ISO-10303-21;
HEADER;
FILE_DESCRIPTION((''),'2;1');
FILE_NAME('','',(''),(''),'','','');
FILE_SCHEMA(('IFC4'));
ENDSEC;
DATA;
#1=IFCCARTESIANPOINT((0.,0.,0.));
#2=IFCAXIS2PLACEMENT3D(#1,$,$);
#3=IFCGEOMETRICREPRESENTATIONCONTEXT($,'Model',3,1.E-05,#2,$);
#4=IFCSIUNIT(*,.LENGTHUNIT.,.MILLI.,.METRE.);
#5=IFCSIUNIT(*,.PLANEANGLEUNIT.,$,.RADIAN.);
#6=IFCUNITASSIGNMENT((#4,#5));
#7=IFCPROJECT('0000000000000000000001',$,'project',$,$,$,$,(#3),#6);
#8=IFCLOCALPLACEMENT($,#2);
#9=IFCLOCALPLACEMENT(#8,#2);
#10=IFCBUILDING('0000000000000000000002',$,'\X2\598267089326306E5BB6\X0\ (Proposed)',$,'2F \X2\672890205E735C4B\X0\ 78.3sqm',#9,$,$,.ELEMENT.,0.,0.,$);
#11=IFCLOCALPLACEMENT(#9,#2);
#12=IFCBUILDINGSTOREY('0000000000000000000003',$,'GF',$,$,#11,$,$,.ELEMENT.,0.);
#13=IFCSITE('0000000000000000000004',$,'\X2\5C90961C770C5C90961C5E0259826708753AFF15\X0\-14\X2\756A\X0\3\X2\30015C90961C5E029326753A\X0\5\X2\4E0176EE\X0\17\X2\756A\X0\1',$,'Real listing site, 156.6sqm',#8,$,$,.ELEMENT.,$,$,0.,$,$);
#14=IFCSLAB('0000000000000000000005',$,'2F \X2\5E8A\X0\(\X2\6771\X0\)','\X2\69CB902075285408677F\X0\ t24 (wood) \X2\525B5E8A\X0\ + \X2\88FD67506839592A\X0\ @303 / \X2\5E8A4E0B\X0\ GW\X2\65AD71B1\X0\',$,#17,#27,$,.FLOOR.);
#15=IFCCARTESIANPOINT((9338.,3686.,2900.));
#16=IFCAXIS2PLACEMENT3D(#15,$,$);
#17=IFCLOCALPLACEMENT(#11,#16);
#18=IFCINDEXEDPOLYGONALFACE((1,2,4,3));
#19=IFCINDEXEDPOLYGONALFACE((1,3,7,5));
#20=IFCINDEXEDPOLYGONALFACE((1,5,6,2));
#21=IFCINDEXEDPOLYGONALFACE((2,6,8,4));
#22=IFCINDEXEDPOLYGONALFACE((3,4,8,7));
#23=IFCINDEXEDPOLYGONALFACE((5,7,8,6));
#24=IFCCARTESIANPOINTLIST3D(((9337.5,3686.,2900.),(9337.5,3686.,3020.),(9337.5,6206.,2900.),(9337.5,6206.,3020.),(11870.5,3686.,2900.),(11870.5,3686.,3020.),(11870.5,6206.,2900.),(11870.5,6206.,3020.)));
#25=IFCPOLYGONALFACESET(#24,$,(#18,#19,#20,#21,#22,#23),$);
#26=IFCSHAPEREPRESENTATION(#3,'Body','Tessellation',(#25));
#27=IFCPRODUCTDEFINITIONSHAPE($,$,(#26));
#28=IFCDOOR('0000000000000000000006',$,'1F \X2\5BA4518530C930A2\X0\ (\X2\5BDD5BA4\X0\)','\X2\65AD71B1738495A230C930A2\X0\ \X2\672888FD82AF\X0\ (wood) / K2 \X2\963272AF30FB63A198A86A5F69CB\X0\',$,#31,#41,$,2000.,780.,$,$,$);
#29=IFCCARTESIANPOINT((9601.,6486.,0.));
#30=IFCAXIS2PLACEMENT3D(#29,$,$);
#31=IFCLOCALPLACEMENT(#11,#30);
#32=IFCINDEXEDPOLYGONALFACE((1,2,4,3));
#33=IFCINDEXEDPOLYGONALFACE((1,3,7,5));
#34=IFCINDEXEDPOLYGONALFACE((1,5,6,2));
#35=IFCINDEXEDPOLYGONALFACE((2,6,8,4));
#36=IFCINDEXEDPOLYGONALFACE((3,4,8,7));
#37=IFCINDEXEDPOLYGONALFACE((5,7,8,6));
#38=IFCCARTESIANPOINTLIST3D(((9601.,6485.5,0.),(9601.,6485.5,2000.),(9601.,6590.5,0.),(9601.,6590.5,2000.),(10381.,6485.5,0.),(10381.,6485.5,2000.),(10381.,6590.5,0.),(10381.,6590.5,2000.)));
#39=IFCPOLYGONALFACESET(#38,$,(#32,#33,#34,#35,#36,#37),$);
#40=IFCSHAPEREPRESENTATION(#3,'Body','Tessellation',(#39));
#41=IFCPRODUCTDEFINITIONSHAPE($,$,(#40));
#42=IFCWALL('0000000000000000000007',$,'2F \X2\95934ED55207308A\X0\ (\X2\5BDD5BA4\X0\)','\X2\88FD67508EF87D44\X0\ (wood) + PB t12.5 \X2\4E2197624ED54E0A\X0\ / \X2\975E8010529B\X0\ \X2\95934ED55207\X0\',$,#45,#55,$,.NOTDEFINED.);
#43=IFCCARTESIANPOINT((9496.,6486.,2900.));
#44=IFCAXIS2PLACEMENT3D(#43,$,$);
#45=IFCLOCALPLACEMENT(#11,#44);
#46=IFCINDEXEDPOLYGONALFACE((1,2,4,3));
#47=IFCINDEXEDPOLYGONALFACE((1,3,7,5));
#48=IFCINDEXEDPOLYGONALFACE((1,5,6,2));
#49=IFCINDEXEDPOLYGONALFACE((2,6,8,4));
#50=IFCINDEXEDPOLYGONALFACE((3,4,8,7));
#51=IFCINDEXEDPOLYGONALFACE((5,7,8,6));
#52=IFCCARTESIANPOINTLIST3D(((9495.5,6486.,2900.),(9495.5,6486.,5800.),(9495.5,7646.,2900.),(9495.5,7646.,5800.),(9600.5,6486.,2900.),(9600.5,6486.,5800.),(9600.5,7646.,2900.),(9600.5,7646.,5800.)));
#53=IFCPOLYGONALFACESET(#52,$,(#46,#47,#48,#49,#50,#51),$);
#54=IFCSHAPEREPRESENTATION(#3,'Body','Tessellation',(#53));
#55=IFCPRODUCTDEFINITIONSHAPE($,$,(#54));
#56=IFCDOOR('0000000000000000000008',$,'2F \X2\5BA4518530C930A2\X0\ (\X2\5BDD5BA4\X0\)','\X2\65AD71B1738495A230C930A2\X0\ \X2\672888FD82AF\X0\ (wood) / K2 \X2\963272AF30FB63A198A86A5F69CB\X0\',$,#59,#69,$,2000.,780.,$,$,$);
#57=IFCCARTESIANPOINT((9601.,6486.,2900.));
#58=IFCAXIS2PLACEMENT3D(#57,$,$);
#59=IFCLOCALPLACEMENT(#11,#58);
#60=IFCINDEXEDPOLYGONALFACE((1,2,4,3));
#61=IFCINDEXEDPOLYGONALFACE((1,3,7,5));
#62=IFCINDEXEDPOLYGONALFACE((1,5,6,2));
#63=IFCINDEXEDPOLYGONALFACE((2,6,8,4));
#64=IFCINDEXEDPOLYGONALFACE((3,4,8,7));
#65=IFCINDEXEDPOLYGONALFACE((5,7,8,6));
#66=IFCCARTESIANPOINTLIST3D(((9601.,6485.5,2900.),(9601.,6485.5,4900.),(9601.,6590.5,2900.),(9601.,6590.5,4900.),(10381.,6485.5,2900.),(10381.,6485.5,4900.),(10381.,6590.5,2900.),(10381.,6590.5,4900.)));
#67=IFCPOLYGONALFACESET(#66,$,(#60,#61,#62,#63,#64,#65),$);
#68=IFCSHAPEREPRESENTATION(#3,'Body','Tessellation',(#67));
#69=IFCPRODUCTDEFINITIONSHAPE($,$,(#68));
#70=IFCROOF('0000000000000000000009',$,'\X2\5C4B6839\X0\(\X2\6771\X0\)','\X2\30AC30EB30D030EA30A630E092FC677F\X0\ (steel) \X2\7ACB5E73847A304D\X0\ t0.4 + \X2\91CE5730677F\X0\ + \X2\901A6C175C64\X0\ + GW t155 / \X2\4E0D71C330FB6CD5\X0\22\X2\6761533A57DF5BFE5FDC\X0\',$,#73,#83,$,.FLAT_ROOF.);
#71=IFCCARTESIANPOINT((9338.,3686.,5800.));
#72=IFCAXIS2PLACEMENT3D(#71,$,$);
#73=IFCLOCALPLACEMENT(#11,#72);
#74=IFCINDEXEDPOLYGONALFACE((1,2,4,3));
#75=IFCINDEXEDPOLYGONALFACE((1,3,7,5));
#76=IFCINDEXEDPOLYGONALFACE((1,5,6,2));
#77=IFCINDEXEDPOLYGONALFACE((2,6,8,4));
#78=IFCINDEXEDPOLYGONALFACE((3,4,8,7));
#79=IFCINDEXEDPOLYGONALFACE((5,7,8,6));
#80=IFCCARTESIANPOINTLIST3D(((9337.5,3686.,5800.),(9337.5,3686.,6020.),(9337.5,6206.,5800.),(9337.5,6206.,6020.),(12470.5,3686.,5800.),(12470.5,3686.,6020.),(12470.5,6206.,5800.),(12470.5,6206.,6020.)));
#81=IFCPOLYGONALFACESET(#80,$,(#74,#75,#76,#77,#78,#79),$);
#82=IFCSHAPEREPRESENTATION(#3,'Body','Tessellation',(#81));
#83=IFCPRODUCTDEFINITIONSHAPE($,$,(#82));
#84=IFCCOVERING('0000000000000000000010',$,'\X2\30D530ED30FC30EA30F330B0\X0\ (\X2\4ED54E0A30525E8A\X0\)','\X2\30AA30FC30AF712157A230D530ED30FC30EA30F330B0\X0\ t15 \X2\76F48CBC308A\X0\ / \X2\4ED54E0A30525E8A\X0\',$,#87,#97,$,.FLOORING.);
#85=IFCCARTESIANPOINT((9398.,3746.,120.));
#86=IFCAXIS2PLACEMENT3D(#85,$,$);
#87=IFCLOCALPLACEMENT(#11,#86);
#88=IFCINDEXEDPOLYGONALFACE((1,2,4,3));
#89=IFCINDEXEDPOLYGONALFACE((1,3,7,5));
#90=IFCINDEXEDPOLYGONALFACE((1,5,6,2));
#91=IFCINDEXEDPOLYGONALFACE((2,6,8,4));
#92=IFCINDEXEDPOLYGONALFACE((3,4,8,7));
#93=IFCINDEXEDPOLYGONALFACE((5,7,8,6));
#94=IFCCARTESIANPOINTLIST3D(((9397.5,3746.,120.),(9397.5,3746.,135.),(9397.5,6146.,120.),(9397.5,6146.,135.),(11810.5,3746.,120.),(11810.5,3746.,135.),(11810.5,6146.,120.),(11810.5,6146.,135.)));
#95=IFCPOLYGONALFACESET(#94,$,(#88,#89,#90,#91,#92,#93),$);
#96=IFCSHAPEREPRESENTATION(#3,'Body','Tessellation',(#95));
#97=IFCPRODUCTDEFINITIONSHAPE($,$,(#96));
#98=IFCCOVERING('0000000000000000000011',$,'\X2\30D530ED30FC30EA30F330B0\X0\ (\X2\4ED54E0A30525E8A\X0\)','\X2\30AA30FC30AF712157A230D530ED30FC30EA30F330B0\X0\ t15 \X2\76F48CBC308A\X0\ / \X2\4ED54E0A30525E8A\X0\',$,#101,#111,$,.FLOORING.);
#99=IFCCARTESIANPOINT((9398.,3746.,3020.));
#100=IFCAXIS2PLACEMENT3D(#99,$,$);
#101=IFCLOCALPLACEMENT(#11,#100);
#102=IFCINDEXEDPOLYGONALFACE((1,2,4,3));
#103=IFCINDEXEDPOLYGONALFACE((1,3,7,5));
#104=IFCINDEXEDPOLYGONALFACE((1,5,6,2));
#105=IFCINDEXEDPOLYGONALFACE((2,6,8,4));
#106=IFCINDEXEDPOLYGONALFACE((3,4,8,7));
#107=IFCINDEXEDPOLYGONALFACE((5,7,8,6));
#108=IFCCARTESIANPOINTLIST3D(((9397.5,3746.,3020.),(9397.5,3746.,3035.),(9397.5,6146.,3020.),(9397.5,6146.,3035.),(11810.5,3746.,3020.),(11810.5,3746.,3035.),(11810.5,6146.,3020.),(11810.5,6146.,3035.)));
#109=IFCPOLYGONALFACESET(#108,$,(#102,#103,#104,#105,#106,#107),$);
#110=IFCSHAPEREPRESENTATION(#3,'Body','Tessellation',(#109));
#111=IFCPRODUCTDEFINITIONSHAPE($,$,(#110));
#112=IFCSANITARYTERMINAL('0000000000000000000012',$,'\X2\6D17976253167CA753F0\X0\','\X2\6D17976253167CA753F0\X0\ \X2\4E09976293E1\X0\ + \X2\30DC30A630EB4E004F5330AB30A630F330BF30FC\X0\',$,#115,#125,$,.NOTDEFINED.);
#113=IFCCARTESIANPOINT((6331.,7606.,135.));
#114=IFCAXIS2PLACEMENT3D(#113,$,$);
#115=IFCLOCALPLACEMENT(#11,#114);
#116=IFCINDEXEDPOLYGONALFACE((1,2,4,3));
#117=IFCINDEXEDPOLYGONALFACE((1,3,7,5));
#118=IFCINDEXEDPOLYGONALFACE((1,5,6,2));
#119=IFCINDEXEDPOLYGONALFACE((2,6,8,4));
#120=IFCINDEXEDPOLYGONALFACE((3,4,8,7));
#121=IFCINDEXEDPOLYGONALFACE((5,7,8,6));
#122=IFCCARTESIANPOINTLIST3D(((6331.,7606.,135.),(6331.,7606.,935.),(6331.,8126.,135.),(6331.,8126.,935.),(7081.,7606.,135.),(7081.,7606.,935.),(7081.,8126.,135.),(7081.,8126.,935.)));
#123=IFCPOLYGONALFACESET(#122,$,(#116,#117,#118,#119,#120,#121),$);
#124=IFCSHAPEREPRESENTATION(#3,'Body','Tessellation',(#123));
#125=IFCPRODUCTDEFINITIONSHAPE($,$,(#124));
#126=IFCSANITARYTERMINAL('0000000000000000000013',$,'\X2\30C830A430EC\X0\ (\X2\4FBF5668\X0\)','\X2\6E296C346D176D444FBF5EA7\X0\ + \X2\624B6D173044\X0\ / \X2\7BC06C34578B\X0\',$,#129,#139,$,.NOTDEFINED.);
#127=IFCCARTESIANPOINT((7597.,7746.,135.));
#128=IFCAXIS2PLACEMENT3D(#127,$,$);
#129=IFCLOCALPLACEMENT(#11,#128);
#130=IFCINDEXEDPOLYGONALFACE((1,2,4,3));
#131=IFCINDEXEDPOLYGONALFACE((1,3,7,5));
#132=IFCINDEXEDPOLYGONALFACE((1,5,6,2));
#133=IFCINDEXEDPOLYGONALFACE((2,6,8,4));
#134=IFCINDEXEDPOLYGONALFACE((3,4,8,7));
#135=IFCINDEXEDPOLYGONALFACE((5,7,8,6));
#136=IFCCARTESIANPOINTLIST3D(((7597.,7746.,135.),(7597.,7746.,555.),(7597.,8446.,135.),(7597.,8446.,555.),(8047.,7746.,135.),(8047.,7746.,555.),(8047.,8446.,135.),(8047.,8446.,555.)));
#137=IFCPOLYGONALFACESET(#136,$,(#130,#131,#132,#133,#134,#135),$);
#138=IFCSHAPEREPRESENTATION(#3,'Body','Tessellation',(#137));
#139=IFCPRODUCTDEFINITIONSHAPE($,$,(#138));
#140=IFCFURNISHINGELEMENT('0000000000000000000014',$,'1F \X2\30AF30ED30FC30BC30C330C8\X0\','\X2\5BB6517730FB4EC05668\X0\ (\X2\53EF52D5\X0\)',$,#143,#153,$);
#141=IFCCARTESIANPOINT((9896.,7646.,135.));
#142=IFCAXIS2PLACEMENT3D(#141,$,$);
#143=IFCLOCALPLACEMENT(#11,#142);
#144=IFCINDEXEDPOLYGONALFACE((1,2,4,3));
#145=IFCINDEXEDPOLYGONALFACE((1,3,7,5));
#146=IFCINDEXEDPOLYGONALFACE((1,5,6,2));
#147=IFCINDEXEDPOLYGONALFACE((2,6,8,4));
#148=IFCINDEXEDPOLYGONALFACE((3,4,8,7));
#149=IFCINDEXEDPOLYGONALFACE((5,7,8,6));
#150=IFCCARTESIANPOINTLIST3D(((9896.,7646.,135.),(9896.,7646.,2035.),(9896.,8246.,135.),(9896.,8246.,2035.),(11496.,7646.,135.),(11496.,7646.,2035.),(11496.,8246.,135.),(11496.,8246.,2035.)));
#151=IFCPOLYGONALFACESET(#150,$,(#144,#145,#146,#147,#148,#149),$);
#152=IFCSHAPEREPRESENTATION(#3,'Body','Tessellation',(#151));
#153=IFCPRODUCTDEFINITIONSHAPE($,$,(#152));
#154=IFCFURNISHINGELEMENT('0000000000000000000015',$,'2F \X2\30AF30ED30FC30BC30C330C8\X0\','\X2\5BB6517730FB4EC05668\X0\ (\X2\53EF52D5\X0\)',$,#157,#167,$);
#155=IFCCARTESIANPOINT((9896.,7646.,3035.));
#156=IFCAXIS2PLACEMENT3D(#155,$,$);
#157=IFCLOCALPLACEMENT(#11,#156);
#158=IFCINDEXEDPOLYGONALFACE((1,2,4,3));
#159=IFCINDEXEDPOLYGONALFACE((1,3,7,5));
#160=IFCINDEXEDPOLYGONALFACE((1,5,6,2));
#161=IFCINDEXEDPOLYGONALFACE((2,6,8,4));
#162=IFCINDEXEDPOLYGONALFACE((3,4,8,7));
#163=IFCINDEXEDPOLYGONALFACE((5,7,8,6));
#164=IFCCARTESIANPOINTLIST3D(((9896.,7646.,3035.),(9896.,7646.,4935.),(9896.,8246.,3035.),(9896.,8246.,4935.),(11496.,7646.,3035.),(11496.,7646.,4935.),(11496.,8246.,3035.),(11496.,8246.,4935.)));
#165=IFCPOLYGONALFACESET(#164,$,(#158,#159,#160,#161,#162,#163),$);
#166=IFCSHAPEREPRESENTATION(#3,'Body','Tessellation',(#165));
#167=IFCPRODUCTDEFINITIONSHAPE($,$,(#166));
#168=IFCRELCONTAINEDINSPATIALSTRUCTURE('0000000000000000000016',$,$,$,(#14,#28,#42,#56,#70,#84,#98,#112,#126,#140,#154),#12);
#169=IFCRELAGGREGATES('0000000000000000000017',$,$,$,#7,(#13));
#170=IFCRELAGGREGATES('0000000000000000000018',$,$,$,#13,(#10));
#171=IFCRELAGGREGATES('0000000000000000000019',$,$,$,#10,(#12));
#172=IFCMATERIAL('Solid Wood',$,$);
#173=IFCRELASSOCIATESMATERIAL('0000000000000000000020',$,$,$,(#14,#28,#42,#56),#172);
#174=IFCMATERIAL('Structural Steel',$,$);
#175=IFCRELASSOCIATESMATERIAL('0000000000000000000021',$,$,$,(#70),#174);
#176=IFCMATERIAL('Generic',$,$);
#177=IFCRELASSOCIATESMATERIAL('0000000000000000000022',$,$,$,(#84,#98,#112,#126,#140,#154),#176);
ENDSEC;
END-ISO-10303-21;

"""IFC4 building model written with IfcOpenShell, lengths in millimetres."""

from ifc_helpers import new_model, si_unit, frame, frame_2d, origin, place, context, project, spatial, rectangle, extrude, material, element, save


model = new_model("IFC4")

# Units and contexts
model_context = context("Model", 3, precision=1e-05, world=origin())
ifc_project = project(units=[si_unit("LENGTHUNIT", "METRE", prefix="MILLI"), si_unit("PLANEANGLEUNIT", "RADIAN")], contexts=[model_context])

# Site, building, storey
site_placement = place(None, origin())
site = spatial("IfcSite", under=ifc_project, at=site_placement, Name="岐阜県岐阜市如月町５-14番3、岐阜市錦町5丁目17番1", ObjectType="Real listing site, 156.6sqm", CompositionType="ELEMENT", RefElevation=0.0)
building_placement = place(site_placement, origin())
building = spatial("IfcBuilding", under=site, at=building_placement, Name="如月錦の家 (Proposed)", ObjectType="2F 木造平屋 78.3sqm", CompositionType="ELEMENT", ElevationOfRefHeight=0.0, ElevationOfTerrain=0.0)
storey_placement = place(building_placement, origin())
storey = spatial("IfcBuildingStorey", under=building, at=storey_placement, Name="GF", CompositionType="ELEMENT", Elevation=0.0)

# Slab
ifc_material_1 = material(Name="Solid Wood")
slab_1_placement = place(storey_placement, frame((9338.0, 3686.0, 2900.0)))
element("IfcSlab", 1, at=slab_1_placement, inside=storey, material=ifc_material_1, Name="2F 床(東)", Description="構造用合板 t24 (wood) 剛床 + 製材根太 @303 / 床下 GW断熱", PredefinedType="FLOOR", context=model_context, shape_type="SweptSolid", body=[
    extrude(rectangle(XDim=2533.0, YDim=2520.0, at=frame_2d((1266.0, 1260.0))), frame((9338.0, 3686.0, 2900.0)), (0.0, 0.0, 1.0), 120.0),
])

# Door
door_1_placement = place(storey_placement, frame((9601.0, 6486.0, 0.0)))
element("IfcDoor", 2, at=door_1_placement, inside=storey, material=ifc_material_1, Name="1F 室内ドア (寝室)", Description="断熱玄関ドア 木製芯 (wood) / K2 防犯・採風機構", OverallHeight=2000.0, OverallWidth=780.0, context=model_context, shape_type="SweptSolid", body=[
    extrude(rectangle(XDim=780.0, YDim=105.0, at=frame_2d((390.0, 52.0))), frame((9601.0, 6486.0, 0.0)), (0.0, 0.0, 1.0), 2000.0),
])

# Wall
wall_1_placement = place(storey_placement, frame((9496.0, 6486.0, 2900.0)))
element("IfcWall", 3, at=wall_1_placement, inside=storey, material=ifc_material_1, Name="2F 間仕切り (寝室)", Description="製材軸組 (wood) + PB t12.5 両面仕上 / 非耐力 間仕切", PredefinedType="NOTDEFINED", context=model_context, shape_type="SweptSolid", body=[
    extrude(rectangle(XDim=105.0, YDim=1160.0, at=frame_2d((52.0, 580.0))), frame((9496.0, 6486.0, 2900.0)), (0.0, 0.0, 1.0), 2900.0),
])

# Door
door_2_placement = place(storey_placement, frame((9601.0, 6486.0, 2900.0)))
element("IfcDoor", 4, at=door_2_placement, inside=storey, material=ifc_material_1, Name="2F 室内ドア (寝室)", Description="断熱玄関ドア 木製芯 (wood) / K2 防犯・採風機構", OverallHeight=2000.0, OverallWidth=780.0, context=model_context, shape_type="SweptSolid", body=[
    extrude(rectangle(XDim=780.0, YDim=105.0, at=frame_2d((390.0, 52.0))), frame((9601.0, 6486.0, 2900.0)), (0.0, 0.0, 1.0), 2000.0),
])

# Roof
ifc_material_2 = material(Name="Structural Steel")
for number, where, name in (
    (5, (9338.0, 3686.0, 5800.0), "屋根(東)"),
):
    element("IfcRoof", number, at=place(storey_placement, frame(where)), inside=storey, material=ifc_material_2, Name=name, Description="ガルバリウム鋼板 (steel) 立平葺き t0.4 + 野地板 + 通気層 + GW t155 / 不燃・法22条区域対応", PredefinedType="FLAT_ROOF", context=model_context, shape_type="SweptSolid", body=[
        extrude(rectangle(XDim=3133.0, YDim=2520.0, at=frame_2d((1566.0, 1260.0))), frame((9338.0, 3686.0, 5800.0)), (0.0, 0.0, 1.0), 220.0),
    ])

# Coverings
ifc_material_3 = material(Name="Generic")
covering_1_placement = place(storey_placement, frame((9398.0, 3746.0, 120.0)))
element("IfcCovering", 6, at=covering_1_placement, inside=storey, material=ifc_material_3, Name="フローリング (仕上げ床)", Description="オーク無垢フローリング t15 直貼り / 仕上げ床", PredefinedType="FLOORING", context=model_context, shape_type="SweptSolid", body=[
    extrude(rectangle(XDim=2413.0, YDim=2400.0, at=frame_2d((1206.0, 1200.0))), frame((9398.0, 3746.0, 120.0)), (0.0, 0.0, 1.0), 15.0),
])
covering_2_placement = place(storey_placement, frame((9398.0, 3746.0, 3020.0)))
element("IfcCovering", 7, at=covering_2_placement, inside=storey, material=ifc_material_3, Name="フローリング (仕上げ床)", Description="オーク無垢フローリング t15 直貼り / 仕上げ床", PredefinedType="FLOORING", context=model_context, shape_type="SweptSolid", body=[
    extrude(rectangle(XDim=2413.0, YDim=2400.0, at=frame_2d((1206.0, 1200.0))), frame((9398.0, 3746.0, 3020.0)), (0.0, 0.0, 1.0), 15.0),
])

# Sanitary terminals
sanitary_terminal_1_placement = place(storey_placement, frame((6331.0, 7606.0, 135.0)))
element("IfcSanitaryTerminal", 8, at=sanitary_terminal_1_placement, inside=storey, material=ifc_material_3, Name="洗面化粧台", Description="洗面化粧台 三面鏡 + ボウル一体カウンター", PredefinedType="NOTDEFINED", context=model_context, shape_type="SweptSolid", body=[
    extrude(rectangle(XDim=750.0, YDim=520.0, at=frame_2d((375.0, 260.0))), frame((6331.0, 7606.0, 135.0)), (0.0, 0.0, 1.0), 800.0),
])
sanitary_terminal_2_placement = place(storey_placement, frame((7597.0, 7746.0, 135.0)))
element("IfcSanitaryTerminal", 9, at=sanitary_terminal_2_placement, inside=storey, material=ifc_material_3, Name="トイレ (便器)", Description="温水洗浄便座 + 手洗い / 節水型", PredefinedType="NOTDEFINED", context=model_context, shape_type="SweptSolid", body=[
    extrude(rectangle(XDim=450.0, YDim=700.0, at=frame_2d((225.0, 350.0))), frame((7597.0, 7746.0, 135.0)), (0.0, 0.0, 1.0), 420.0),
])

# Furnishing elements
furnishing_1_placement = place(storey_placement, frame((9896.0, 7646.0, 135.0)))
element("IfcFurnishingElement", 10, at=furnishing_1_placement, inside=storey, material=ifc_material_3, Name="1F クローゼット", Description="家具・什器 (可動)", context=model_context, shape_type="SweptSolid", body=[
    extrude(rectangle(XDim=1600.0, YDim=600.0, at=frame_2d((800.0, 300.0))), frame((9896.0, 7646.0, 135.0)), (0.0, 0.0, 1.0), 1900.0),
])
furnishing_2_placement = place(storey_placement, frame((9896.0, 7646.0, 3035.0)))
element("IfcFurnishingElement", 11, at=furnishing_2_placement, inside=storey, material=ifc_material_3, Name="2F クローゼット", Description="家具・什器 (可動)", context=model_context, shape_type="SweptSolid", body=[
    extrude(rectangle(XDim=1600.0, YDim=600.0, at=frame_2d((800.0, 300.0))), frame((9896.0, 7646.0, 3035.0)), (0.0, 0.0, 1.0), 1900.0),
])

save(model, "model.ifc")
